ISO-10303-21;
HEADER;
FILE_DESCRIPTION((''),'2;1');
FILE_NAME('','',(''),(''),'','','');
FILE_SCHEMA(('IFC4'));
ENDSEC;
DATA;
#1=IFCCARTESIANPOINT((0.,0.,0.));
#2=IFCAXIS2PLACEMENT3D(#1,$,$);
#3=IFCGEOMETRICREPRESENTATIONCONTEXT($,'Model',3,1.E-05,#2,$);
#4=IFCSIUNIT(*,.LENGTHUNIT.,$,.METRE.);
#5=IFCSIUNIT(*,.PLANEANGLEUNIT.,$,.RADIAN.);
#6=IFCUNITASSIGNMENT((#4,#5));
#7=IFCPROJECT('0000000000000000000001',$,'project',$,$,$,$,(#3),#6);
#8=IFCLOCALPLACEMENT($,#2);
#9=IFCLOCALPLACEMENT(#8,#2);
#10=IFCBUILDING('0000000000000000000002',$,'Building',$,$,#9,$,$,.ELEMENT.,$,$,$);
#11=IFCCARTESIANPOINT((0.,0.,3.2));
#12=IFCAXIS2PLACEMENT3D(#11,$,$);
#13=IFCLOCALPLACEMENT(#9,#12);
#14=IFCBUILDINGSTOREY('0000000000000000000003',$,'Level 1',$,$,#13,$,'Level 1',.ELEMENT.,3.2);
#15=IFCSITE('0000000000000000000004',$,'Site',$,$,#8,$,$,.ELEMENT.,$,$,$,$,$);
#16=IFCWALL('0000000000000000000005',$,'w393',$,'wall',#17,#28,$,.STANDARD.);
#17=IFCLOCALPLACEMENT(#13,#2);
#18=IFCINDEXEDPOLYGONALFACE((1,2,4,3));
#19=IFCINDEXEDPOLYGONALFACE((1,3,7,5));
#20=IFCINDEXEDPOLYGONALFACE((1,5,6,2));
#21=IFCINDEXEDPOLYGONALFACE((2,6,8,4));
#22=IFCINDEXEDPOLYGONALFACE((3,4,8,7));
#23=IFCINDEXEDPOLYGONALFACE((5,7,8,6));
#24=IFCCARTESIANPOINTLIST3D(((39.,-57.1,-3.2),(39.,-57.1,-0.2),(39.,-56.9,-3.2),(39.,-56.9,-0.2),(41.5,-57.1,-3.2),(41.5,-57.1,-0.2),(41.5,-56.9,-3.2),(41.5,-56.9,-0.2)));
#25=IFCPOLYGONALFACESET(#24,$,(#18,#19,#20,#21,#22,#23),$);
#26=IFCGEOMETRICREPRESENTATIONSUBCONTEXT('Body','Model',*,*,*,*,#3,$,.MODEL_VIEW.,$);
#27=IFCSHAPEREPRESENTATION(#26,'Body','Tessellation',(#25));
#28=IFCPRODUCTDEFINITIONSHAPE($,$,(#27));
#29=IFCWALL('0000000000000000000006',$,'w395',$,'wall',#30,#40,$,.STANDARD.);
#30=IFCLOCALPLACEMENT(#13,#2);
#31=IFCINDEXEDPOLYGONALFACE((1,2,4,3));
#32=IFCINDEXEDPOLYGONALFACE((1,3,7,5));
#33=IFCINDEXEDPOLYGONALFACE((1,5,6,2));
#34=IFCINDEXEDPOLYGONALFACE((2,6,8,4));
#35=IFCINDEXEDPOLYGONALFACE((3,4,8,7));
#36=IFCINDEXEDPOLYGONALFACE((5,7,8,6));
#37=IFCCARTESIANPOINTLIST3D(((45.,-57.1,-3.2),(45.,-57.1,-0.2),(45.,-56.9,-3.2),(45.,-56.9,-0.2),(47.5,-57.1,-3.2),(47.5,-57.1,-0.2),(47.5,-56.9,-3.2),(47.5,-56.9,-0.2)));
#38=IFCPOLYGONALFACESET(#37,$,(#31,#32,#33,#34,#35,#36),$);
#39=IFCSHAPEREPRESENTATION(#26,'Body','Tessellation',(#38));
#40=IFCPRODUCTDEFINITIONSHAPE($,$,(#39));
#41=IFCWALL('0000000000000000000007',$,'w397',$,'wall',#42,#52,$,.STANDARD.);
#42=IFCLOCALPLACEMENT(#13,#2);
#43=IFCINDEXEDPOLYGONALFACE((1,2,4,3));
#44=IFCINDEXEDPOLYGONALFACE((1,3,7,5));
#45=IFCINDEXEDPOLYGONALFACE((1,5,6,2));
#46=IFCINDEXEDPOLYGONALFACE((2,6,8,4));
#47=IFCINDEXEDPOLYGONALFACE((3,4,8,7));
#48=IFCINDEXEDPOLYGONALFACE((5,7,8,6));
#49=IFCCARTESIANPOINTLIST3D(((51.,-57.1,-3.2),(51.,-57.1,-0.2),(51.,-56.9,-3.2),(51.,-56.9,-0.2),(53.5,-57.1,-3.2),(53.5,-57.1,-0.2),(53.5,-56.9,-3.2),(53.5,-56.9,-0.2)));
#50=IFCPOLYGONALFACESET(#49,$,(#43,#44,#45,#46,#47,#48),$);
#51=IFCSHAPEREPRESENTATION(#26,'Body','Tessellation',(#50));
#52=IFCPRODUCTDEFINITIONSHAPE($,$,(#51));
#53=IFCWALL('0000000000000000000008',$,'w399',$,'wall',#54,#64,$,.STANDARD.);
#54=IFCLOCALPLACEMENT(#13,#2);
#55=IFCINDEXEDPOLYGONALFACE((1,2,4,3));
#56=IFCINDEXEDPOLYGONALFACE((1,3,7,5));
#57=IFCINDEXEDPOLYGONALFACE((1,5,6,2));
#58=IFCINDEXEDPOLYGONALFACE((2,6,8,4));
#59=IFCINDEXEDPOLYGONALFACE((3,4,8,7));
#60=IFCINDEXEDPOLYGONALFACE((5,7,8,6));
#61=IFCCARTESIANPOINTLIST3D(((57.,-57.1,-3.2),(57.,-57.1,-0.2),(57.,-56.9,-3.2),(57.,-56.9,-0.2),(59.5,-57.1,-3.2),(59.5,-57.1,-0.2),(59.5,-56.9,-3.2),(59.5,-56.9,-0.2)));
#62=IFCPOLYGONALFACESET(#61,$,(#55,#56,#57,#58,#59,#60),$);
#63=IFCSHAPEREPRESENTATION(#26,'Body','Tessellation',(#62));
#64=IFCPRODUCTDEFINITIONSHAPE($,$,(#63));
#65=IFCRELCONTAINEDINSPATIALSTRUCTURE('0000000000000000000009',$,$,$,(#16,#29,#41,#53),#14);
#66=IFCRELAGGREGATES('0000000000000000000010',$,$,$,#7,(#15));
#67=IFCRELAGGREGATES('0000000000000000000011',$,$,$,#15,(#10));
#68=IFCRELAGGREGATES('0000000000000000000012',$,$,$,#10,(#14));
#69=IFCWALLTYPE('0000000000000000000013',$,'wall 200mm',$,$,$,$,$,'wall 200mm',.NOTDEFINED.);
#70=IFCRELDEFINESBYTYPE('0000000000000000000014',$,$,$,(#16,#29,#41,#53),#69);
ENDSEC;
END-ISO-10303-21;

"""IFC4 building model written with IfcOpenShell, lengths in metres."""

from ifc_helpers import new_model, si_unit, frame, frame_2d, origin, place, context, subcontext, project, spatial, rectangle, extrude, type_object, element, save


model = new_model("IFC4")

# Units and contexts
model_context = context("Model", 3, precision=1e-05, world=origin())
body_context = subcontext(model_context, "Body", "Model", "MODEL_VIEW")
ifc_project = project(units=[si_unit("LENGTHUNIT", "METRE"), si_unit("PLANEANGLEUNIT", "RADIAN")], contexts=[model_context])

# Site, building, storey
site_placement = place(None, origin())
site = spatial("IfcSite", under=ifc_project, at=site_placement, Name="Site", CompositionType="ELEMENT")
building_placement = place(site_placement, origin())
building = spatial("IfcBuilding", under=site, at=building_placement, Name="Building", CompositionType="ELEMENT")
storey_placement = place(building_placement, frame((0.0, 0.0, 3.2)))
storey = spatial("IfcBuildingStorey", under=building, at=storey_placement, Name="Level 1", LongName="Level 1", CompositionType="ELEMENT", Elevation=3.2)

# Walls
wall_type = type_object("IfcWallType", Name="wall 200mm", ElementType="wall 200mm", PredefinedType="NOTDEFINED")
for number, where, z_axis, x_axis, name in (
    (1, (39.0, -57.0, -3.2), (0.0, 0.0, 1.0), (1.0, 0.0, 0.0), "w393"),
    (2, (45.0, -57.0, -3.2), (0.0, 0.0, 1.0), (1.0, 0.0, 0.0), "w395"),
    (3, (51.0, -57.0, -3.2), (0.0, 0.0, 1.0), (1.0, 0.0, 0.0), "w397"),
    (4, (57.0, -57.0, -3.2), (0.0, 0.0, 1.0), (1.0, 0.0, 0.0), "w399"),
):
    element("IfcWall", number, at=place(storey_placement, frame(where, z_axis=z_axis, x_axis=x_axis)), inside=storey, type_object=wall_type, Name=name, ObjectType="wall", PredefinedType="STANDARD", context=body_context, shape_type="SweptSolid", body=[
        extrude(rectangle(XDim=2.5, YDim=0.2, at=frame_2d((1.25, 0.0))), origin(), (0.0, 0.0, 1.0), 3.0),
    ])

save(model, "model.ifc")
